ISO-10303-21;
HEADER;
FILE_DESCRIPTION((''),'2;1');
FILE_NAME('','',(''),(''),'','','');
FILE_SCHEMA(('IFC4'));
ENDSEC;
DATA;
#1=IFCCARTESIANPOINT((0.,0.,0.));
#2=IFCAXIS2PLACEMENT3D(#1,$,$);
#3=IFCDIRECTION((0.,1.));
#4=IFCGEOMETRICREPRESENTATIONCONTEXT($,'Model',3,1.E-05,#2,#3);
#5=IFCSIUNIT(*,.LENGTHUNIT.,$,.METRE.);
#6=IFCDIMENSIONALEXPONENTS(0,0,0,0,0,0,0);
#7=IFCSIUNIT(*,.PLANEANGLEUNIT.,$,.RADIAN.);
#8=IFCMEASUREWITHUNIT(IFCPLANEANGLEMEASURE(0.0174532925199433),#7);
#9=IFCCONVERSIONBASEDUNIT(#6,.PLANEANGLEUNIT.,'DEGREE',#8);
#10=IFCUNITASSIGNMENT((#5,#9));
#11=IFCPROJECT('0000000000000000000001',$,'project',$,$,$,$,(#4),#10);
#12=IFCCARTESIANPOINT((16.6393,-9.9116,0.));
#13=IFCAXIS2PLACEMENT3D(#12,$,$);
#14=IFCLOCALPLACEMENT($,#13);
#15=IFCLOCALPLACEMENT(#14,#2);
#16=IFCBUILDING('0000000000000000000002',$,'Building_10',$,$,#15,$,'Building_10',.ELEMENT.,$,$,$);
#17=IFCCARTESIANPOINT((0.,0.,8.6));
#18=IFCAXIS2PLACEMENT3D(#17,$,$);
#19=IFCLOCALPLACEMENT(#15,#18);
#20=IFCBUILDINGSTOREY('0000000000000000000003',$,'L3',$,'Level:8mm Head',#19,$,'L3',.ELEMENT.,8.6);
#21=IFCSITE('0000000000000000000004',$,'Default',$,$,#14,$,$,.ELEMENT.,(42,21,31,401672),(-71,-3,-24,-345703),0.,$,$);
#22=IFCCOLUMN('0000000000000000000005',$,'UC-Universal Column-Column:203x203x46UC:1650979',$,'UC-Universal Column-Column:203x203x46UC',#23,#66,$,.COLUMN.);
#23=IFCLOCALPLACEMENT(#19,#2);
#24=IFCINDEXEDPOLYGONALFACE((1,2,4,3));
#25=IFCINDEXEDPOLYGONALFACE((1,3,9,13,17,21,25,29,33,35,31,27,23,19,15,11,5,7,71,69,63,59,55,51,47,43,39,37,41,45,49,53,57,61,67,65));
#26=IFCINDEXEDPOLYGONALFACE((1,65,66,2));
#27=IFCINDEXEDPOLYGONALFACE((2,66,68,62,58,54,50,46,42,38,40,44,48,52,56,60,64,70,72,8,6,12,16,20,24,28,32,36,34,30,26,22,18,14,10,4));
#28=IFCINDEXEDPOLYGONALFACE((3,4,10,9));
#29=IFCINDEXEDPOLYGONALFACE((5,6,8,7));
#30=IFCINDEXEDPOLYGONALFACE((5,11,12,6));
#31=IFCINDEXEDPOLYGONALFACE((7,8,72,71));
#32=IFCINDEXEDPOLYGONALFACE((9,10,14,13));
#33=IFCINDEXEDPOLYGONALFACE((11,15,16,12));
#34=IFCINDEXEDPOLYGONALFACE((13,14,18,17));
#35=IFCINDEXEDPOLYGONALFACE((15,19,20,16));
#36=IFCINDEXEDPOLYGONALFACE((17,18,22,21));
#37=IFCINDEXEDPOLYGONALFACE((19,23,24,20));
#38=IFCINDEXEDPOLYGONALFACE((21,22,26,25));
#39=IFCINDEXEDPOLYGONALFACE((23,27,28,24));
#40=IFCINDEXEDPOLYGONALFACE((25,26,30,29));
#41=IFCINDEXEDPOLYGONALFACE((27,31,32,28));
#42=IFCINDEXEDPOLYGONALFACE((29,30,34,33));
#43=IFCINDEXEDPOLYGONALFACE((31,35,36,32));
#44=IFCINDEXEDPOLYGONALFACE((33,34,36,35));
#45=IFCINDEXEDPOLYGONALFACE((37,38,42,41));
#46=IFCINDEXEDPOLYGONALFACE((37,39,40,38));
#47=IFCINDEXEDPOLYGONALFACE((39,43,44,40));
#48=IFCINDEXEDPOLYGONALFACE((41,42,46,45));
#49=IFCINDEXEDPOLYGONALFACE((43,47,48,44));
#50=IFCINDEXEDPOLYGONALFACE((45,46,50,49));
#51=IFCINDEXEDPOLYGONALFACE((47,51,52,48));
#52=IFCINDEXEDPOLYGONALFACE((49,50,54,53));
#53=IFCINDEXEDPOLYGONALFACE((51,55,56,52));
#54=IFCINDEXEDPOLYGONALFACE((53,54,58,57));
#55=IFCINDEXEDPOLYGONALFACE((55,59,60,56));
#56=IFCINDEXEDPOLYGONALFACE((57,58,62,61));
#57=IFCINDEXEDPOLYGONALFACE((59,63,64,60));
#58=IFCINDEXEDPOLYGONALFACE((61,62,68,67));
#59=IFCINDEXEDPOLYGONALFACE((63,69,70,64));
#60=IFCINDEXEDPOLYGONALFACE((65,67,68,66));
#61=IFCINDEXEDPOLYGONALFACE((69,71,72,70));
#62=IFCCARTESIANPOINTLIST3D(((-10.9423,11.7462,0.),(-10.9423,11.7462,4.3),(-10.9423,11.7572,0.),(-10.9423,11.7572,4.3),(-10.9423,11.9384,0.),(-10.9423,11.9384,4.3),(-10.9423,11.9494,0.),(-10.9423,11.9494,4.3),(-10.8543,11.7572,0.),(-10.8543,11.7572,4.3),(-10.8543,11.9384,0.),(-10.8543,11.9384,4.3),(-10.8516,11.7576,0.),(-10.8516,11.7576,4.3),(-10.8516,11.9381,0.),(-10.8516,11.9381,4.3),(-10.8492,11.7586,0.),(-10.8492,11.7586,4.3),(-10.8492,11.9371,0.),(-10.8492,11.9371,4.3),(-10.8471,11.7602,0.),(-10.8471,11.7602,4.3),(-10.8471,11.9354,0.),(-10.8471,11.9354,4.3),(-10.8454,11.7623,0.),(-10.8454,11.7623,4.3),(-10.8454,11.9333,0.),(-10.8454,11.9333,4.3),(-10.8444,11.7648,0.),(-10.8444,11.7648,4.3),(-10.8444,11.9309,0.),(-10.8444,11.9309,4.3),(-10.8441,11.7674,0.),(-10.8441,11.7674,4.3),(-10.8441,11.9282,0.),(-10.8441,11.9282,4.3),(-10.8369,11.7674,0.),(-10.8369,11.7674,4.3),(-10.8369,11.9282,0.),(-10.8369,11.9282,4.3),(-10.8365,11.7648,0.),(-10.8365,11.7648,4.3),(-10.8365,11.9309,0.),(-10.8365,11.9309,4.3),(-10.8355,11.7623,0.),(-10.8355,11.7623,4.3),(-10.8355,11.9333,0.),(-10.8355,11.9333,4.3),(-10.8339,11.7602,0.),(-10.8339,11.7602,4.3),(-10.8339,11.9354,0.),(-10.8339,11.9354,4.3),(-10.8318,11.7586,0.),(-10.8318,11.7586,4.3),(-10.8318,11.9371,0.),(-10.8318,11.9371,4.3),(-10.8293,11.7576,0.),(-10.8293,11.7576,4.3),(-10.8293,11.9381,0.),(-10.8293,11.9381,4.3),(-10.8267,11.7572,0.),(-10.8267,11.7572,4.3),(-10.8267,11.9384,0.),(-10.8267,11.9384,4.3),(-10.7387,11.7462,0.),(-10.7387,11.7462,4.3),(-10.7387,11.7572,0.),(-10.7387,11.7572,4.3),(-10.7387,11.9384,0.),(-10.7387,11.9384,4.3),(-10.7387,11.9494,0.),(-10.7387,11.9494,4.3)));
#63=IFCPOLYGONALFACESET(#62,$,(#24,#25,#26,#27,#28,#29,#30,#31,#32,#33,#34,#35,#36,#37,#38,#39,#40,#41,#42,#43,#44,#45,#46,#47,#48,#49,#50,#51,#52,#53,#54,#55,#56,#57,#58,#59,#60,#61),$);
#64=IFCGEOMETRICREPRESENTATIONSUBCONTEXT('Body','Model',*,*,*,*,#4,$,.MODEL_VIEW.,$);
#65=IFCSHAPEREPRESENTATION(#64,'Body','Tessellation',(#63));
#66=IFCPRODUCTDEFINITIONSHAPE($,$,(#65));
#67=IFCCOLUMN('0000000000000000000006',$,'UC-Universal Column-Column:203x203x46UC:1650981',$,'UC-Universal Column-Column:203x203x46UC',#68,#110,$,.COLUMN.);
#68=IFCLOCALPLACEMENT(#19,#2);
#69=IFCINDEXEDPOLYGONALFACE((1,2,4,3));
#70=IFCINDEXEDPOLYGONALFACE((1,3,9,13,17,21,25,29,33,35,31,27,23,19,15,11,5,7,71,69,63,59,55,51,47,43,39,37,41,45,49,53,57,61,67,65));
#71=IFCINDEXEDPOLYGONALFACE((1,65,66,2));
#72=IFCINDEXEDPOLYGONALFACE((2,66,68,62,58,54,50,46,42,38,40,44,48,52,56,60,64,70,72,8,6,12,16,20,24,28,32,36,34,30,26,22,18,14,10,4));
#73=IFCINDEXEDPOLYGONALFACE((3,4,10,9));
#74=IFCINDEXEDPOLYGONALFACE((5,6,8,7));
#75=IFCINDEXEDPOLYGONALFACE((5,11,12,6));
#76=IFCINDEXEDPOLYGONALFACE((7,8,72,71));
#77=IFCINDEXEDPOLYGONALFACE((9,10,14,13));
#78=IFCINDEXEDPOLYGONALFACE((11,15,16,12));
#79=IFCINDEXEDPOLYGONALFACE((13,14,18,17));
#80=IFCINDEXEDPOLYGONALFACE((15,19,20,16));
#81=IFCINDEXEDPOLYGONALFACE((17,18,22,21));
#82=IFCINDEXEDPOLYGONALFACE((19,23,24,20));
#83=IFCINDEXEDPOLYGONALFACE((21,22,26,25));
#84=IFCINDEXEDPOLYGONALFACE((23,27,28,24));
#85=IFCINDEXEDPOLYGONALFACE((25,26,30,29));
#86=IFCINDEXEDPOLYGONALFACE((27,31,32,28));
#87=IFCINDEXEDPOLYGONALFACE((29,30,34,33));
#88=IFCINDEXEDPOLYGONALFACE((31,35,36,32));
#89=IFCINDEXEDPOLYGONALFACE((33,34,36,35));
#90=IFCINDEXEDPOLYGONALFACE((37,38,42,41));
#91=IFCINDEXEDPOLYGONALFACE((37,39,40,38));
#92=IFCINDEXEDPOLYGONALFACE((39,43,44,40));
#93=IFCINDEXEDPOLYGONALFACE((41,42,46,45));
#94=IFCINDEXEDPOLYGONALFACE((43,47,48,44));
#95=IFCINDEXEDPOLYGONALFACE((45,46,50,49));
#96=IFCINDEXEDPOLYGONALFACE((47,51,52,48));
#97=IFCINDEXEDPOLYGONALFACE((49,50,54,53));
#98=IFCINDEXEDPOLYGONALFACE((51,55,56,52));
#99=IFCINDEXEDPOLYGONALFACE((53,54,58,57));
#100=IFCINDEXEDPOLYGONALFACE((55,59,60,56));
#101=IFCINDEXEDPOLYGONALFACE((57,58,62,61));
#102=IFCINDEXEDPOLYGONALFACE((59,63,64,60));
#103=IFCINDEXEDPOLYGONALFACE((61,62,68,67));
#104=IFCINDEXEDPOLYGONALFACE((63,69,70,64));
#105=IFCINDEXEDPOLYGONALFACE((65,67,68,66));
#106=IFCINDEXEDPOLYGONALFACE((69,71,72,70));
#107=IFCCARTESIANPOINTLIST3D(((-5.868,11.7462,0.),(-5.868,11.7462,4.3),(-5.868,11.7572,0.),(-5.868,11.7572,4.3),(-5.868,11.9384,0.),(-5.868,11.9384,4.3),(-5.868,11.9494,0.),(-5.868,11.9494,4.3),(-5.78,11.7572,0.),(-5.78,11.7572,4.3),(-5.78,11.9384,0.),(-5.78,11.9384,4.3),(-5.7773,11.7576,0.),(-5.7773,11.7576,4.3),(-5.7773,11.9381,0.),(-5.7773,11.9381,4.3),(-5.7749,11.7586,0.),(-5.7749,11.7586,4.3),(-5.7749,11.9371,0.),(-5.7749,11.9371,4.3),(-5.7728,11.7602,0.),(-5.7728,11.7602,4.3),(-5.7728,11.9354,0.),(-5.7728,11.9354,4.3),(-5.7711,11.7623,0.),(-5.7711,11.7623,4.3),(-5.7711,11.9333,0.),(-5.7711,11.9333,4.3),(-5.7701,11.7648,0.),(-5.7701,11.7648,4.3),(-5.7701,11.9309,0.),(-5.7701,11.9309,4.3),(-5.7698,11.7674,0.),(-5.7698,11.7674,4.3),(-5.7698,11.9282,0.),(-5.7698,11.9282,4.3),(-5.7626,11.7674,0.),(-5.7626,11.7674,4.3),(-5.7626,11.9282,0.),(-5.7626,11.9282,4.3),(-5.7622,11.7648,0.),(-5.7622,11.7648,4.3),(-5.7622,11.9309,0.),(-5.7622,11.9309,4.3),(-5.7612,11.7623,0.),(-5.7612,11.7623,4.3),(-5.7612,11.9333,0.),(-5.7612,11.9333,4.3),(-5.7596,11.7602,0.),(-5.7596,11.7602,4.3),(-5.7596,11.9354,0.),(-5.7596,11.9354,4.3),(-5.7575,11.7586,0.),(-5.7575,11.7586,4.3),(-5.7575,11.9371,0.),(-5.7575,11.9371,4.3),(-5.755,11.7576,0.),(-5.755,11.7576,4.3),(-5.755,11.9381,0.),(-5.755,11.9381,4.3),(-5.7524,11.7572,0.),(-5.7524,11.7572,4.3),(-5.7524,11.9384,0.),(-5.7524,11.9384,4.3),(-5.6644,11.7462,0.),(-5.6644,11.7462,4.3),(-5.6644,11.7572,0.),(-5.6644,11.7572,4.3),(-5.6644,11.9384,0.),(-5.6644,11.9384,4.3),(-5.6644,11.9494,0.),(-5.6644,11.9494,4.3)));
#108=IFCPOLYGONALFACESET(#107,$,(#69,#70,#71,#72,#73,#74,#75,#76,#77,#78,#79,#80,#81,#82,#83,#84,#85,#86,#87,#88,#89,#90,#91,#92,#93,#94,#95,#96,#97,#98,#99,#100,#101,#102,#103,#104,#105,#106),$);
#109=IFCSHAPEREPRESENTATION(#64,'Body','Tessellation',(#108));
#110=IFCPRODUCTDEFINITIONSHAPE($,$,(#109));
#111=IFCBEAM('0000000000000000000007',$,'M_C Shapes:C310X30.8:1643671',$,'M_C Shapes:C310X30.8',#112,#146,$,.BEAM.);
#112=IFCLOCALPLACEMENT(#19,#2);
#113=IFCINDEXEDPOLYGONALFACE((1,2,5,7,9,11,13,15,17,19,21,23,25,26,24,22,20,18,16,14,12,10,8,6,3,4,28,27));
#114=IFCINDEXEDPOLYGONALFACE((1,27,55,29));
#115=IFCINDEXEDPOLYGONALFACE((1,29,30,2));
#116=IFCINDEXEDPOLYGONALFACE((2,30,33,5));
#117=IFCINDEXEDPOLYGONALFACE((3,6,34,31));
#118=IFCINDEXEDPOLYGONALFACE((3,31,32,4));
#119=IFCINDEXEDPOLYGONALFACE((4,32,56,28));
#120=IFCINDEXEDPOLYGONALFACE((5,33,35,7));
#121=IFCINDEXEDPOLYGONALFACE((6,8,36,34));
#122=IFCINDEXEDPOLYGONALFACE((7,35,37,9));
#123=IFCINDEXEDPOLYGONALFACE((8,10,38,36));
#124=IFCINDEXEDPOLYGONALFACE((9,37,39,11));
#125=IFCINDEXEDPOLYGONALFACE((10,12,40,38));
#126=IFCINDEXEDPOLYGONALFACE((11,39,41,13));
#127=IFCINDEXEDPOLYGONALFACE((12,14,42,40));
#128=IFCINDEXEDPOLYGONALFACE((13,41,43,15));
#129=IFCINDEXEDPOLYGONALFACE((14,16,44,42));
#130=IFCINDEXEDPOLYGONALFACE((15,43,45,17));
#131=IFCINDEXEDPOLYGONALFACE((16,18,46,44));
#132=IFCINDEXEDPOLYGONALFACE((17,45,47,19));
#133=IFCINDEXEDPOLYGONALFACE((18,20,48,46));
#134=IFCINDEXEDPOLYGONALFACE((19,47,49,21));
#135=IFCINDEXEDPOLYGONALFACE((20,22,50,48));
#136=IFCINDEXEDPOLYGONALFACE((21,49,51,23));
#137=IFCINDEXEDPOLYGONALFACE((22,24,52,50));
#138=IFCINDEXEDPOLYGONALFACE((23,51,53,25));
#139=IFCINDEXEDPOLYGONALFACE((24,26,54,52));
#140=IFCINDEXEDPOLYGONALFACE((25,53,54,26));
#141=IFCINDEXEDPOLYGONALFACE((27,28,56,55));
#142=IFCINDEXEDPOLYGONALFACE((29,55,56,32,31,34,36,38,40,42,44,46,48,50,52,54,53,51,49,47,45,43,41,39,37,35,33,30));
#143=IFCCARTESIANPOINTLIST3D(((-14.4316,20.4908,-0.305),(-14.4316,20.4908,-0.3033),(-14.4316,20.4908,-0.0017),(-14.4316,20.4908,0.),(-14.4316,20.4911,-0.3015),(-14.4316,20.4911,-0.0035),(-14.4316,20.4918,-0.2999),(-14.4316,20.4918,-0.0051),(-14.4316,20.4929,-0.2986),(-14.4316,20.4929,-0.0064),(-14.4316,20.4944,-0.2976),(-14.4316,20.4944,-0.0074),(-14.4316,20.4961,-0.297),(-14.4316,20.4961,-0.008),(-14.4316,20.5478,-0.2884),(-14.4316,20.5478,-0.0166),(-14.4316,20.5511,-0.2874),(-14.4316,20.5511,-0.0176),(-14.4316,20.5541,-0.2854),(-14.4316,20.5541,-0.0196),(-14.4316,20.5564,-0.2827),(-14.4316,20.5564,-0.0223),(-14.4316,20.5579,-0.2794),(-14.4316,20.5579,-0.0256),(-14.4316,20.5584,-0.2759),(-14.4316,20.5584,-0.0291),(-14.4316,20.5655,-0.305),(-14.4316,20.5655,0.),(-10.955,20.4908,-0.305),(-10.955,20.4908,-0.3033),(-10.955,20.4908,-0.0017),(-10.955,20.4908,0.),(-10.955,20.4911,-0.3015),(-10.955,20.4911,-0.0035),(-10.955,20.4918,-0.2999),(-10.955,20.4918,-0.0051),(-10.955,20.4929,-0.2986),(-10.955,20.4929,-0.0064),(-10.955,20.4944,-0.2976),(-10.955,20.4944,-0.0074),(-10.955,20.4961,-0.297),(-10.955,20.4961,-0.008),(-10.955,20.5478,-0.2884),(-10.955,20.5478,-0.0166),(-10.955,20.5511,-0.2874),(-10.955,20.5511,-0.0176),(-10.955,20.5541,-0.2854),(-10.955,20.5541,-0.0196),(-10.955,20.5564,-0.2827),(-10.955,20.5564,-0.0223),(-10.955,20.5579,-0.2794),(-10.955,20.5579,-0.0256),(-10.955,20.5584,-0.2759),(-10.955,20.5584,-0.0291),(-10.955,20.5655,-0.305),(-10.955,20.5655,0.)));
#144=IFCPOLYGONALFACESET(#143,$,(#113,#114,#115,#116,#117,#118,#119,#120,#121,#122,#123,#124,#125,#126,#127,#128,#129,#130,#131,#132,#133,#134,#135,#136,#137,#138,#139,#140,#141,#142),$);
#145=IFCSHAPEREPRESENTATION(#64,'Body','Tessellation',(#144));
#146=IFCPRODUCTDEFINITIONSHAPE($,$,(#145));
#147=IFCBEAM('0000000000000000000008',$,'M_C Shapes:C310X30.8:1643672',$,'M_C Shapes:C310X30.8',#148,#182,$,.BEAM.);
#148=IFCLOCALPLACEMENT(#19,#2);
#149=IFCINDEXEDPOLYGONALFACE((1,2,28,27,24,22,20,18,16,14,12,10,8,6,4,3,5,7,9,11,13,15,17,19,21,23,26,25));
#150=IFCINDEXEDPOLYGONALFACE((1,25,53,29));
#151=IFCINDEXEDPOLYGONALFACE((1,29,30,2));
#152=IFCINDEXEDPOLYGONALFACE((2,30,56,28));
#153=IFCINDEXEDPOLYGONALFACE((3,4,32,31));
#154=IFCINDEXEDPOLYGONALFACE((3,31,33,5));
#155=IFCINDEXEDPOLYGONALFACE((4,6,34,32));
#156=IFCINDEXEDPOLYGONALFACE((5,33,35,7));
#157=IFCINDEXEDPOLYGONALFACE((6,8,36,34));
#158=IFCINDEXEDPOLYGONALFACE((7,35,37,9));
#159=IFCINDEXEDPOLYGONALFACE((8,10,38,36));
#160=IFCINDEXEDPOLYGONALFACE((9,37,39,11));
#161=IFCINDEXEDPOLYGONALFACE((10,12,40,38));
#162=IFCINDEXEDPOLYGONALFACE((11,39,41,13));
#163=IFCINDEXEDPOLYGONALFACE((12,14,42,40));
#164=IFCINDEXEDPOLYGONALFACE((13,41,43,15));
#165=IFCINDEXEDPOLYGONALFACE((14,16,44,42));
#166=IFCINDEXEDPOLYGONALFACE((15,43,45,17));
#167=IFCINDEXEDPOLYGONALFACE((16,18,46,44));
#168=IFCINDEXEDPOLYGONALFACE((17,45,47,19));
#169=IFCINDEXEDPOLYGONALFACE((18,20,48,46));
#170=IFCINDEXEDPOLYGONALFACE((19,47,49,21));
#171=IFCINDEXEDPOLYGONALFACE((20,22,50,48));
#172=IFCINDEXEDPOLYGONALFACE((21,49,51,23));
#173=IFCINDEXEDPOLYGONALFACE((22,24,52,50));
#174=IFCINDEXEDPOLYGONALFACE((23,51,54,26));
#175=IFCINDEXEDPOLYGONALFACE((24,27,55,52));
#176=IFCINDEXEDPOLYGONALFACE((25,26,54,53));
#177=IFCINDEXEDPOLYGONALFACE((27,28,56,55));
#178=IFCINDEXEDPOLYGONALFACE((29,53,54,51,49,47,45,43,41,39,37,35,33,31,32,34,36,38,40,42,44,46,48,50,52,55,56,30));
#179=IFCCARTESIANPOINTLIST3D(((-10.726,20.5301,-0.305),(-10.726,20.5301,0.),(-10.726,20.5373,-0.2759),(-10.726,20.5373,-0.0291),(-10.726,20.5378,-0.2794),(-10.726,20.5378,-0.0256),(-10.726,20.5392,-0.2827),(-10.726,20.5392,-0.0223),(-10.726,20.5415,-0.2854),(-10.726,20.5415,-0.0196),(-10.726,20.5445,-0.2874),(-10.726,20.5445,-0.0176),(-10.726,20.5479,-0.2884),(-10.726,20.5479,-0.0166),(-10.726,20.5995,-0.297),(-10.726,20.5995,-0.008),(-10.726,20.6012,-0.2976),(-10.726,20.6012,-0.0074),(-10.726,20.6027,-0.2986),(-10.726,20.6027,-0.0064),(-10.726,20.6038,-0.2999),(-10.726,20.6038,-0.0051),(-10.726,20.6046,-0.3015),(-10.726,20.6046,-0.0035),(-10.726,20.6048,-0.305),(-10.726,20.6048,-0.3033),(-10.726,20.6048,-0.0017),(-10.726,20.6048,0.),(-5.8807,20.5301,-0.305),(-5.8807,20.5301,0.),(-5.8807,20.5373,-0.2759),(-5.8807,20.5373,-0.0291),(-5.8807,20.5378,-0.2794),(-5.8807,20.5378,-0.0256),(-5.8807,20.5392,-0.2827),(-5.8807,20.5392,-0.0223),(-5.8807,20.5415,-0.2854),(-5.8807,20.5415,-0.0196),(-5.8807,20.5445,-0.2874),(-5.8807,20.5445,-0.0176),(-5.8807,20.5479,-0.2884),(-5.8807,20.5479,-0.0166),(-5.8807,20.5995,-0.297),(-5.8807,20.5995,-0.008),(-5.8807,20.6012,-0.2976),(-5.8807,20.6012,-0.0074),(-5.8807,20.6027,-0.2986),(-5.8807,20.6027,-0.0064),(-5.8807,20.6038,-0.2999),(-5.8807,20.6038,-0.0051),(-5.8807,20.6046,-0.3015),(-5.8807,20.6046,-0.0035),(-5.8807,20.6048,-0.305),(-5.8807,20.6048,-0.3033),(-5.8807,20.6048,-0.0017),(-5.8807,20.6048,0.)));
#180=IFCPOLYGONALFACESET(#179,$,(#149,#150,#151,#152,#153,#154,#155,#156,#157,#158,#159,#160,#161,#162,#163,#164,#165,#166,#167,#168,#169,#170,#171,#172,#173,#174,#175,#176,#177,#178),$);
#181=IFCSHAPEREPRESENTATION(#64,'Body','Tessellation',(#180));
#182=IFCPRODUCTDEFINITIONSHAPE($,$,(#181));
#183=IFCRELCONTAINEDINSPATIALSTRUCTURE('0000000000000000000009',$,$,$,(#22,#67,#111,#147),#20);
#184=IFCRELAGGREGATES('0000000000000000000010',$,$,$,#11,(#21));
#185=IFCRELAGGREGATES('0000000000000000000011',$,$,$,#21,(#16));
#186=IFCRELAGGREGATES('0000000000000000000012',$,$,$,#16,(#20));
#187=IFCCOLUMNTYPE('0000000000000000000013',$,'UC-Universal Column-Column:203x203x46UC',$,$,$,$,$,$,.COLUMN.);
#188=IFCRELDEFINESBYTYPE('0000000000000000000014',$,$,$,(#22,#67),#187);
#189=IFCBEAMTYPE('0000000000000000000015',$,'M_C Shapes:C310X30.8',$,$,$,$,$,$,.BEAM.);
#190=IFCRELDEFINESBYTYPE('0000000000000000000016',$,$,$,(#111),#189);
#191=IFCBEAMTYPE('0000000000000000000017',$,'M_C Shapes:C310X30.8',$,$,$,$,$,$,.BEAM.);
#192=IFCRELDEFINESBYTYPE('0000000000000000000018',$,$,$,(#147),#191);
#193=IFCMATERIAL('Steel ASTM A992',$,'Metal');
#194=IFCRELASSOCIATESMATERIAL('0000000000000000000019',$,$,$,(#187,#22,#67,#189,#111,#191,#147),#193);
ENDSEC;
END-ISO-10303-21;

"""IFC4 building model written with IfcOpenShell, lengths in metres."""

from ifc_helpers import new_model, entity, si_unit, converted_unit, direction, frame, origin, place, context, subcontext, project, spatial, line, arc, indexed_curve, outline, extrude, source, transform, mapped, material, type_object, type_shapes, element, save


model = new_model("IFC4")

# Units and contexts
model_context = context("Model", 3, precision=1e-05, world=origin(), true_north=direction((0.0, 1.0)))
body_context = subcontext(model_context, "Body", "Model", "MODEL_VIEW")
ifc_project = project(units=[si_unit("LENGTHUNIT", "METRE"), converted_unit("PLANEANGLEUNIT", "DEGREE", entity("IfcPlaneAngleMeasure", 0.0174532925199433), si_unit("PLANEANGLEUNIT", "RADIAN"), dimensions=[0, 0, 0, 0, 0, 0, 0])], contexts=[model_context])

# Site, building, storey
site_placement = place(None, frame((16.6393, -9.9116, 0.0)))
site = spatial("IfcSite", under=ifc_project, at=site_placement, Name="Default", CompositionType="ELEMENT", RefLatitude=(42, 21, 31, 401672), RefLongitude=(-71, -3, -24, -345703), RefElevation=0.0)
building_placement = place(site_placement, origin())
building = spatial("IfcBuilding", under=site, at=building_placement, Name="Building_10", LongName="Building_10", CompositionType="ELEMENT")
storey_placement = place(building_placement, frame((0.0, 0.0, 8.6)))
storey = spatial("IfcBuildingStorey", under=building, at=storey_placement, Name="L3", ObjectType="Level:8mm Head", LongName="L3", CompositionType="ELEMENT", Elevation=8.6)

# Columns
ifc_material_1 = material(Name="Steel ASTM A992", Category="Metal")
column_type = type_object("IfcColumnType", Name="UC-Universal Column-Column:203x203x46UC", PredefinedType="COLUMN", material=ifc_material_1)
shared_shape_1 = source(origin(), body_context, "Body", "SweptSolid", [
    extrude(outline(indexed_curve([(-0.1018, -0.1016), (0.1018, -0.1016), (0.1018, -0.0906), (0.0138, -0.0906), (0.0066, -0.0876), (0.0036, -0.0804), (0.0036, 0.0804), (0.0066, 0.0876), (0.0138, 0.0906), (0.1018, 0.0906), (0.1018, 0.1016), (-0.1018, 0.1016), (-0.1018, 0.0906), (-0.0138, 0.0906), (-0.0066, 0.0876), (-0.0036, 0.0804), (-0.0036, -0.0804), (-0.0066, -0.0876), (-0.0138, -0.0906), (-0.1018, -0.0906)], segments=[line(1, 2, 3, 4), arc(4, 5, 6), line(6, 7), arc(7, 8, 9), line(9, 10, 11, 12, 13, 14), arc(14, 15, 16), line(16, 17), arc(17, 18, 19), line(19, 20, 1)], self_intersect=False)), frame((0.0, 0.0, 8.6), z_axis=(0.0, 0.0, 1.0), x_axis=(-1.0, 0.0, 0.0)), (0.0, 0.0, 1.0), 4.3),
])
type_shapes(column_type, [shared_shape_1])
for number, where, name in (
    (1, (-10.8405, 11.8478, -8.6), "UC-Universal Column-Column:203x203x46UC:1650979"),
    (2, (-5.7662, 11.8478, -8.6), "UC-Universal Column-Column:203x203x46UC:1650981"),
):
    element("IfcColumn", number, at=place(storey_placement, frame(where)), inside=storey, type_object=column_type, material=ifc_material_1, Name=name, ObjectType="UC-Universal Column-Column:203x203x46UC", PredefinedType="COLUMN", context=body_context, shape_type="MappedRepresentation", body=[
        mapped(shared_shape_1, transform((0.0, 0.0, 0.0), scale=1.0)),
    ])

# Beams
beam_type_1 = type_object("IfcBeamType", Name="M_C Shapes:C310X30.8", PredefinedType="BEAM", material=ifc_material_1)
shared_shape_2 = source(origin(), body_context, "Body", "SweptSolid", [
    extrude(outline(indexed_curve([(-0.0406, -0.1525), (0.0341, -0.1525), (0.0341, -0.1508), (0.0326, -0.1467), (0.0288, -0.1445), (-0.0228, -0.1359), (-0.0305, -0.1316), (-0.0335, -0.1234), (-0.0335, 0.1234), (-0.0305, 0.1316), (-0.0228, 0.1359), (0.0288, 0.1445), (0.0326, 0.1467), (0.0341, 0.1508), (0.0341, 0.1525), (-0.0406, 0.1525)], segments=[line(1, 2, 3), arc(3, 4, 5), line(5, 6), arc(6, 7, 8), line(8, 9), arc(9, 10, 11), line(11, 12), arc(12, 13, 14), line(14, 15, 16, 1)], self_intersect=False)), frame((-1.7383, -0.0229, 0.0), z_axis=(1.0, 0.0, 0.0), x_axis=(0.0, -1.0, 0.0)), (0.0, 0.0, 1.0), 3.4766),
])
type_shapes(beam_type_1, [shared_shape_2])
beam_1_placement = place(storey_placement, frame((-12.6933, 20.5478, -0.1525)))
element("IfcBeam", 3, at=beam_1_placement, inside=storey, type_object=beam_type_1, material=ifc_material_1, Name="M_C Shapes:C310X30.8:1643671", ObjectType="M_C Shapes:C310X30.8", PredefinedType="BEAM", context=body_context, shape_type="MappedRepresentation", body=[
    mapped(shared_shape_2, transform((0.0, 0.0, 0.0), scale=1.0)),
])
beam_type_2 = type_object("IfcBeamType", Name="M_C Shapes:C310X30.8", PredefinedType="BEAM", material=ifc_material_1)
shared_shape_3 = source(origin(), body_context, "Body", "SweptSolid", [
    extrude(outline(indexed_curve([(-0.0406, -0.1525), (0.0341, -0.1525), (0.0341, -0.1508), (0.0326, -0.1467), (0.0288, -0.1445), (-0.0228, -0.1359), (-0.0305, -0.1316), (-0.0335, -0.1234), (-0.0335, 0.1234), (-0.0305, 0.1316), (-0.0228, 0.1359), (0.0288, 0.1445), (0.0326, 0.1467), (0.0341, 0.1508), (0.0341, 0.1525), (-0.0406, 0.1525)], segments=[line(1, 2, 3), arc(3, 4, 5), line(5, 6), arc(6, 7, 8), line(8, 9), arc(9, 10, 11), line(11, 12), arc(12, 13, 14), line(14, 15, 16, 1)], self_intersect=False)), frame((-2.4226, -0.0229, 0.0), z_axis=(1.0, 0.0, 0.0), x_axis=(0.0, -1.0, 0.0)), (0.0, 0.0, 1.0), 4.8453),
])
type_shapes(beam_type_2, [shared_shape_3])
beam_2_placement = place(storey_placement, frame((-8.3033, 20.5478, -0.1525), z_axis=(0.0, 0.0, 1.0), x_axis=(-1.0, 0.0, 0.0)))
element("IfcBeam", 4, at=beam_2_placement, inside=storey, type_object=beam_type_2, material=ifc_material_1, Name="M_C Shapes:C310X30.8:1643672", ObjectType="M_C Shapes:C310X30.8", PredefinedType="BEAM", context=body_context, shape_type="MappedRepresentation", body=[
    mapped(shared_shape_3, transform((0.0, 0.0, 0.0), scale=1.0)),
])

save(model, "model.ifc")
